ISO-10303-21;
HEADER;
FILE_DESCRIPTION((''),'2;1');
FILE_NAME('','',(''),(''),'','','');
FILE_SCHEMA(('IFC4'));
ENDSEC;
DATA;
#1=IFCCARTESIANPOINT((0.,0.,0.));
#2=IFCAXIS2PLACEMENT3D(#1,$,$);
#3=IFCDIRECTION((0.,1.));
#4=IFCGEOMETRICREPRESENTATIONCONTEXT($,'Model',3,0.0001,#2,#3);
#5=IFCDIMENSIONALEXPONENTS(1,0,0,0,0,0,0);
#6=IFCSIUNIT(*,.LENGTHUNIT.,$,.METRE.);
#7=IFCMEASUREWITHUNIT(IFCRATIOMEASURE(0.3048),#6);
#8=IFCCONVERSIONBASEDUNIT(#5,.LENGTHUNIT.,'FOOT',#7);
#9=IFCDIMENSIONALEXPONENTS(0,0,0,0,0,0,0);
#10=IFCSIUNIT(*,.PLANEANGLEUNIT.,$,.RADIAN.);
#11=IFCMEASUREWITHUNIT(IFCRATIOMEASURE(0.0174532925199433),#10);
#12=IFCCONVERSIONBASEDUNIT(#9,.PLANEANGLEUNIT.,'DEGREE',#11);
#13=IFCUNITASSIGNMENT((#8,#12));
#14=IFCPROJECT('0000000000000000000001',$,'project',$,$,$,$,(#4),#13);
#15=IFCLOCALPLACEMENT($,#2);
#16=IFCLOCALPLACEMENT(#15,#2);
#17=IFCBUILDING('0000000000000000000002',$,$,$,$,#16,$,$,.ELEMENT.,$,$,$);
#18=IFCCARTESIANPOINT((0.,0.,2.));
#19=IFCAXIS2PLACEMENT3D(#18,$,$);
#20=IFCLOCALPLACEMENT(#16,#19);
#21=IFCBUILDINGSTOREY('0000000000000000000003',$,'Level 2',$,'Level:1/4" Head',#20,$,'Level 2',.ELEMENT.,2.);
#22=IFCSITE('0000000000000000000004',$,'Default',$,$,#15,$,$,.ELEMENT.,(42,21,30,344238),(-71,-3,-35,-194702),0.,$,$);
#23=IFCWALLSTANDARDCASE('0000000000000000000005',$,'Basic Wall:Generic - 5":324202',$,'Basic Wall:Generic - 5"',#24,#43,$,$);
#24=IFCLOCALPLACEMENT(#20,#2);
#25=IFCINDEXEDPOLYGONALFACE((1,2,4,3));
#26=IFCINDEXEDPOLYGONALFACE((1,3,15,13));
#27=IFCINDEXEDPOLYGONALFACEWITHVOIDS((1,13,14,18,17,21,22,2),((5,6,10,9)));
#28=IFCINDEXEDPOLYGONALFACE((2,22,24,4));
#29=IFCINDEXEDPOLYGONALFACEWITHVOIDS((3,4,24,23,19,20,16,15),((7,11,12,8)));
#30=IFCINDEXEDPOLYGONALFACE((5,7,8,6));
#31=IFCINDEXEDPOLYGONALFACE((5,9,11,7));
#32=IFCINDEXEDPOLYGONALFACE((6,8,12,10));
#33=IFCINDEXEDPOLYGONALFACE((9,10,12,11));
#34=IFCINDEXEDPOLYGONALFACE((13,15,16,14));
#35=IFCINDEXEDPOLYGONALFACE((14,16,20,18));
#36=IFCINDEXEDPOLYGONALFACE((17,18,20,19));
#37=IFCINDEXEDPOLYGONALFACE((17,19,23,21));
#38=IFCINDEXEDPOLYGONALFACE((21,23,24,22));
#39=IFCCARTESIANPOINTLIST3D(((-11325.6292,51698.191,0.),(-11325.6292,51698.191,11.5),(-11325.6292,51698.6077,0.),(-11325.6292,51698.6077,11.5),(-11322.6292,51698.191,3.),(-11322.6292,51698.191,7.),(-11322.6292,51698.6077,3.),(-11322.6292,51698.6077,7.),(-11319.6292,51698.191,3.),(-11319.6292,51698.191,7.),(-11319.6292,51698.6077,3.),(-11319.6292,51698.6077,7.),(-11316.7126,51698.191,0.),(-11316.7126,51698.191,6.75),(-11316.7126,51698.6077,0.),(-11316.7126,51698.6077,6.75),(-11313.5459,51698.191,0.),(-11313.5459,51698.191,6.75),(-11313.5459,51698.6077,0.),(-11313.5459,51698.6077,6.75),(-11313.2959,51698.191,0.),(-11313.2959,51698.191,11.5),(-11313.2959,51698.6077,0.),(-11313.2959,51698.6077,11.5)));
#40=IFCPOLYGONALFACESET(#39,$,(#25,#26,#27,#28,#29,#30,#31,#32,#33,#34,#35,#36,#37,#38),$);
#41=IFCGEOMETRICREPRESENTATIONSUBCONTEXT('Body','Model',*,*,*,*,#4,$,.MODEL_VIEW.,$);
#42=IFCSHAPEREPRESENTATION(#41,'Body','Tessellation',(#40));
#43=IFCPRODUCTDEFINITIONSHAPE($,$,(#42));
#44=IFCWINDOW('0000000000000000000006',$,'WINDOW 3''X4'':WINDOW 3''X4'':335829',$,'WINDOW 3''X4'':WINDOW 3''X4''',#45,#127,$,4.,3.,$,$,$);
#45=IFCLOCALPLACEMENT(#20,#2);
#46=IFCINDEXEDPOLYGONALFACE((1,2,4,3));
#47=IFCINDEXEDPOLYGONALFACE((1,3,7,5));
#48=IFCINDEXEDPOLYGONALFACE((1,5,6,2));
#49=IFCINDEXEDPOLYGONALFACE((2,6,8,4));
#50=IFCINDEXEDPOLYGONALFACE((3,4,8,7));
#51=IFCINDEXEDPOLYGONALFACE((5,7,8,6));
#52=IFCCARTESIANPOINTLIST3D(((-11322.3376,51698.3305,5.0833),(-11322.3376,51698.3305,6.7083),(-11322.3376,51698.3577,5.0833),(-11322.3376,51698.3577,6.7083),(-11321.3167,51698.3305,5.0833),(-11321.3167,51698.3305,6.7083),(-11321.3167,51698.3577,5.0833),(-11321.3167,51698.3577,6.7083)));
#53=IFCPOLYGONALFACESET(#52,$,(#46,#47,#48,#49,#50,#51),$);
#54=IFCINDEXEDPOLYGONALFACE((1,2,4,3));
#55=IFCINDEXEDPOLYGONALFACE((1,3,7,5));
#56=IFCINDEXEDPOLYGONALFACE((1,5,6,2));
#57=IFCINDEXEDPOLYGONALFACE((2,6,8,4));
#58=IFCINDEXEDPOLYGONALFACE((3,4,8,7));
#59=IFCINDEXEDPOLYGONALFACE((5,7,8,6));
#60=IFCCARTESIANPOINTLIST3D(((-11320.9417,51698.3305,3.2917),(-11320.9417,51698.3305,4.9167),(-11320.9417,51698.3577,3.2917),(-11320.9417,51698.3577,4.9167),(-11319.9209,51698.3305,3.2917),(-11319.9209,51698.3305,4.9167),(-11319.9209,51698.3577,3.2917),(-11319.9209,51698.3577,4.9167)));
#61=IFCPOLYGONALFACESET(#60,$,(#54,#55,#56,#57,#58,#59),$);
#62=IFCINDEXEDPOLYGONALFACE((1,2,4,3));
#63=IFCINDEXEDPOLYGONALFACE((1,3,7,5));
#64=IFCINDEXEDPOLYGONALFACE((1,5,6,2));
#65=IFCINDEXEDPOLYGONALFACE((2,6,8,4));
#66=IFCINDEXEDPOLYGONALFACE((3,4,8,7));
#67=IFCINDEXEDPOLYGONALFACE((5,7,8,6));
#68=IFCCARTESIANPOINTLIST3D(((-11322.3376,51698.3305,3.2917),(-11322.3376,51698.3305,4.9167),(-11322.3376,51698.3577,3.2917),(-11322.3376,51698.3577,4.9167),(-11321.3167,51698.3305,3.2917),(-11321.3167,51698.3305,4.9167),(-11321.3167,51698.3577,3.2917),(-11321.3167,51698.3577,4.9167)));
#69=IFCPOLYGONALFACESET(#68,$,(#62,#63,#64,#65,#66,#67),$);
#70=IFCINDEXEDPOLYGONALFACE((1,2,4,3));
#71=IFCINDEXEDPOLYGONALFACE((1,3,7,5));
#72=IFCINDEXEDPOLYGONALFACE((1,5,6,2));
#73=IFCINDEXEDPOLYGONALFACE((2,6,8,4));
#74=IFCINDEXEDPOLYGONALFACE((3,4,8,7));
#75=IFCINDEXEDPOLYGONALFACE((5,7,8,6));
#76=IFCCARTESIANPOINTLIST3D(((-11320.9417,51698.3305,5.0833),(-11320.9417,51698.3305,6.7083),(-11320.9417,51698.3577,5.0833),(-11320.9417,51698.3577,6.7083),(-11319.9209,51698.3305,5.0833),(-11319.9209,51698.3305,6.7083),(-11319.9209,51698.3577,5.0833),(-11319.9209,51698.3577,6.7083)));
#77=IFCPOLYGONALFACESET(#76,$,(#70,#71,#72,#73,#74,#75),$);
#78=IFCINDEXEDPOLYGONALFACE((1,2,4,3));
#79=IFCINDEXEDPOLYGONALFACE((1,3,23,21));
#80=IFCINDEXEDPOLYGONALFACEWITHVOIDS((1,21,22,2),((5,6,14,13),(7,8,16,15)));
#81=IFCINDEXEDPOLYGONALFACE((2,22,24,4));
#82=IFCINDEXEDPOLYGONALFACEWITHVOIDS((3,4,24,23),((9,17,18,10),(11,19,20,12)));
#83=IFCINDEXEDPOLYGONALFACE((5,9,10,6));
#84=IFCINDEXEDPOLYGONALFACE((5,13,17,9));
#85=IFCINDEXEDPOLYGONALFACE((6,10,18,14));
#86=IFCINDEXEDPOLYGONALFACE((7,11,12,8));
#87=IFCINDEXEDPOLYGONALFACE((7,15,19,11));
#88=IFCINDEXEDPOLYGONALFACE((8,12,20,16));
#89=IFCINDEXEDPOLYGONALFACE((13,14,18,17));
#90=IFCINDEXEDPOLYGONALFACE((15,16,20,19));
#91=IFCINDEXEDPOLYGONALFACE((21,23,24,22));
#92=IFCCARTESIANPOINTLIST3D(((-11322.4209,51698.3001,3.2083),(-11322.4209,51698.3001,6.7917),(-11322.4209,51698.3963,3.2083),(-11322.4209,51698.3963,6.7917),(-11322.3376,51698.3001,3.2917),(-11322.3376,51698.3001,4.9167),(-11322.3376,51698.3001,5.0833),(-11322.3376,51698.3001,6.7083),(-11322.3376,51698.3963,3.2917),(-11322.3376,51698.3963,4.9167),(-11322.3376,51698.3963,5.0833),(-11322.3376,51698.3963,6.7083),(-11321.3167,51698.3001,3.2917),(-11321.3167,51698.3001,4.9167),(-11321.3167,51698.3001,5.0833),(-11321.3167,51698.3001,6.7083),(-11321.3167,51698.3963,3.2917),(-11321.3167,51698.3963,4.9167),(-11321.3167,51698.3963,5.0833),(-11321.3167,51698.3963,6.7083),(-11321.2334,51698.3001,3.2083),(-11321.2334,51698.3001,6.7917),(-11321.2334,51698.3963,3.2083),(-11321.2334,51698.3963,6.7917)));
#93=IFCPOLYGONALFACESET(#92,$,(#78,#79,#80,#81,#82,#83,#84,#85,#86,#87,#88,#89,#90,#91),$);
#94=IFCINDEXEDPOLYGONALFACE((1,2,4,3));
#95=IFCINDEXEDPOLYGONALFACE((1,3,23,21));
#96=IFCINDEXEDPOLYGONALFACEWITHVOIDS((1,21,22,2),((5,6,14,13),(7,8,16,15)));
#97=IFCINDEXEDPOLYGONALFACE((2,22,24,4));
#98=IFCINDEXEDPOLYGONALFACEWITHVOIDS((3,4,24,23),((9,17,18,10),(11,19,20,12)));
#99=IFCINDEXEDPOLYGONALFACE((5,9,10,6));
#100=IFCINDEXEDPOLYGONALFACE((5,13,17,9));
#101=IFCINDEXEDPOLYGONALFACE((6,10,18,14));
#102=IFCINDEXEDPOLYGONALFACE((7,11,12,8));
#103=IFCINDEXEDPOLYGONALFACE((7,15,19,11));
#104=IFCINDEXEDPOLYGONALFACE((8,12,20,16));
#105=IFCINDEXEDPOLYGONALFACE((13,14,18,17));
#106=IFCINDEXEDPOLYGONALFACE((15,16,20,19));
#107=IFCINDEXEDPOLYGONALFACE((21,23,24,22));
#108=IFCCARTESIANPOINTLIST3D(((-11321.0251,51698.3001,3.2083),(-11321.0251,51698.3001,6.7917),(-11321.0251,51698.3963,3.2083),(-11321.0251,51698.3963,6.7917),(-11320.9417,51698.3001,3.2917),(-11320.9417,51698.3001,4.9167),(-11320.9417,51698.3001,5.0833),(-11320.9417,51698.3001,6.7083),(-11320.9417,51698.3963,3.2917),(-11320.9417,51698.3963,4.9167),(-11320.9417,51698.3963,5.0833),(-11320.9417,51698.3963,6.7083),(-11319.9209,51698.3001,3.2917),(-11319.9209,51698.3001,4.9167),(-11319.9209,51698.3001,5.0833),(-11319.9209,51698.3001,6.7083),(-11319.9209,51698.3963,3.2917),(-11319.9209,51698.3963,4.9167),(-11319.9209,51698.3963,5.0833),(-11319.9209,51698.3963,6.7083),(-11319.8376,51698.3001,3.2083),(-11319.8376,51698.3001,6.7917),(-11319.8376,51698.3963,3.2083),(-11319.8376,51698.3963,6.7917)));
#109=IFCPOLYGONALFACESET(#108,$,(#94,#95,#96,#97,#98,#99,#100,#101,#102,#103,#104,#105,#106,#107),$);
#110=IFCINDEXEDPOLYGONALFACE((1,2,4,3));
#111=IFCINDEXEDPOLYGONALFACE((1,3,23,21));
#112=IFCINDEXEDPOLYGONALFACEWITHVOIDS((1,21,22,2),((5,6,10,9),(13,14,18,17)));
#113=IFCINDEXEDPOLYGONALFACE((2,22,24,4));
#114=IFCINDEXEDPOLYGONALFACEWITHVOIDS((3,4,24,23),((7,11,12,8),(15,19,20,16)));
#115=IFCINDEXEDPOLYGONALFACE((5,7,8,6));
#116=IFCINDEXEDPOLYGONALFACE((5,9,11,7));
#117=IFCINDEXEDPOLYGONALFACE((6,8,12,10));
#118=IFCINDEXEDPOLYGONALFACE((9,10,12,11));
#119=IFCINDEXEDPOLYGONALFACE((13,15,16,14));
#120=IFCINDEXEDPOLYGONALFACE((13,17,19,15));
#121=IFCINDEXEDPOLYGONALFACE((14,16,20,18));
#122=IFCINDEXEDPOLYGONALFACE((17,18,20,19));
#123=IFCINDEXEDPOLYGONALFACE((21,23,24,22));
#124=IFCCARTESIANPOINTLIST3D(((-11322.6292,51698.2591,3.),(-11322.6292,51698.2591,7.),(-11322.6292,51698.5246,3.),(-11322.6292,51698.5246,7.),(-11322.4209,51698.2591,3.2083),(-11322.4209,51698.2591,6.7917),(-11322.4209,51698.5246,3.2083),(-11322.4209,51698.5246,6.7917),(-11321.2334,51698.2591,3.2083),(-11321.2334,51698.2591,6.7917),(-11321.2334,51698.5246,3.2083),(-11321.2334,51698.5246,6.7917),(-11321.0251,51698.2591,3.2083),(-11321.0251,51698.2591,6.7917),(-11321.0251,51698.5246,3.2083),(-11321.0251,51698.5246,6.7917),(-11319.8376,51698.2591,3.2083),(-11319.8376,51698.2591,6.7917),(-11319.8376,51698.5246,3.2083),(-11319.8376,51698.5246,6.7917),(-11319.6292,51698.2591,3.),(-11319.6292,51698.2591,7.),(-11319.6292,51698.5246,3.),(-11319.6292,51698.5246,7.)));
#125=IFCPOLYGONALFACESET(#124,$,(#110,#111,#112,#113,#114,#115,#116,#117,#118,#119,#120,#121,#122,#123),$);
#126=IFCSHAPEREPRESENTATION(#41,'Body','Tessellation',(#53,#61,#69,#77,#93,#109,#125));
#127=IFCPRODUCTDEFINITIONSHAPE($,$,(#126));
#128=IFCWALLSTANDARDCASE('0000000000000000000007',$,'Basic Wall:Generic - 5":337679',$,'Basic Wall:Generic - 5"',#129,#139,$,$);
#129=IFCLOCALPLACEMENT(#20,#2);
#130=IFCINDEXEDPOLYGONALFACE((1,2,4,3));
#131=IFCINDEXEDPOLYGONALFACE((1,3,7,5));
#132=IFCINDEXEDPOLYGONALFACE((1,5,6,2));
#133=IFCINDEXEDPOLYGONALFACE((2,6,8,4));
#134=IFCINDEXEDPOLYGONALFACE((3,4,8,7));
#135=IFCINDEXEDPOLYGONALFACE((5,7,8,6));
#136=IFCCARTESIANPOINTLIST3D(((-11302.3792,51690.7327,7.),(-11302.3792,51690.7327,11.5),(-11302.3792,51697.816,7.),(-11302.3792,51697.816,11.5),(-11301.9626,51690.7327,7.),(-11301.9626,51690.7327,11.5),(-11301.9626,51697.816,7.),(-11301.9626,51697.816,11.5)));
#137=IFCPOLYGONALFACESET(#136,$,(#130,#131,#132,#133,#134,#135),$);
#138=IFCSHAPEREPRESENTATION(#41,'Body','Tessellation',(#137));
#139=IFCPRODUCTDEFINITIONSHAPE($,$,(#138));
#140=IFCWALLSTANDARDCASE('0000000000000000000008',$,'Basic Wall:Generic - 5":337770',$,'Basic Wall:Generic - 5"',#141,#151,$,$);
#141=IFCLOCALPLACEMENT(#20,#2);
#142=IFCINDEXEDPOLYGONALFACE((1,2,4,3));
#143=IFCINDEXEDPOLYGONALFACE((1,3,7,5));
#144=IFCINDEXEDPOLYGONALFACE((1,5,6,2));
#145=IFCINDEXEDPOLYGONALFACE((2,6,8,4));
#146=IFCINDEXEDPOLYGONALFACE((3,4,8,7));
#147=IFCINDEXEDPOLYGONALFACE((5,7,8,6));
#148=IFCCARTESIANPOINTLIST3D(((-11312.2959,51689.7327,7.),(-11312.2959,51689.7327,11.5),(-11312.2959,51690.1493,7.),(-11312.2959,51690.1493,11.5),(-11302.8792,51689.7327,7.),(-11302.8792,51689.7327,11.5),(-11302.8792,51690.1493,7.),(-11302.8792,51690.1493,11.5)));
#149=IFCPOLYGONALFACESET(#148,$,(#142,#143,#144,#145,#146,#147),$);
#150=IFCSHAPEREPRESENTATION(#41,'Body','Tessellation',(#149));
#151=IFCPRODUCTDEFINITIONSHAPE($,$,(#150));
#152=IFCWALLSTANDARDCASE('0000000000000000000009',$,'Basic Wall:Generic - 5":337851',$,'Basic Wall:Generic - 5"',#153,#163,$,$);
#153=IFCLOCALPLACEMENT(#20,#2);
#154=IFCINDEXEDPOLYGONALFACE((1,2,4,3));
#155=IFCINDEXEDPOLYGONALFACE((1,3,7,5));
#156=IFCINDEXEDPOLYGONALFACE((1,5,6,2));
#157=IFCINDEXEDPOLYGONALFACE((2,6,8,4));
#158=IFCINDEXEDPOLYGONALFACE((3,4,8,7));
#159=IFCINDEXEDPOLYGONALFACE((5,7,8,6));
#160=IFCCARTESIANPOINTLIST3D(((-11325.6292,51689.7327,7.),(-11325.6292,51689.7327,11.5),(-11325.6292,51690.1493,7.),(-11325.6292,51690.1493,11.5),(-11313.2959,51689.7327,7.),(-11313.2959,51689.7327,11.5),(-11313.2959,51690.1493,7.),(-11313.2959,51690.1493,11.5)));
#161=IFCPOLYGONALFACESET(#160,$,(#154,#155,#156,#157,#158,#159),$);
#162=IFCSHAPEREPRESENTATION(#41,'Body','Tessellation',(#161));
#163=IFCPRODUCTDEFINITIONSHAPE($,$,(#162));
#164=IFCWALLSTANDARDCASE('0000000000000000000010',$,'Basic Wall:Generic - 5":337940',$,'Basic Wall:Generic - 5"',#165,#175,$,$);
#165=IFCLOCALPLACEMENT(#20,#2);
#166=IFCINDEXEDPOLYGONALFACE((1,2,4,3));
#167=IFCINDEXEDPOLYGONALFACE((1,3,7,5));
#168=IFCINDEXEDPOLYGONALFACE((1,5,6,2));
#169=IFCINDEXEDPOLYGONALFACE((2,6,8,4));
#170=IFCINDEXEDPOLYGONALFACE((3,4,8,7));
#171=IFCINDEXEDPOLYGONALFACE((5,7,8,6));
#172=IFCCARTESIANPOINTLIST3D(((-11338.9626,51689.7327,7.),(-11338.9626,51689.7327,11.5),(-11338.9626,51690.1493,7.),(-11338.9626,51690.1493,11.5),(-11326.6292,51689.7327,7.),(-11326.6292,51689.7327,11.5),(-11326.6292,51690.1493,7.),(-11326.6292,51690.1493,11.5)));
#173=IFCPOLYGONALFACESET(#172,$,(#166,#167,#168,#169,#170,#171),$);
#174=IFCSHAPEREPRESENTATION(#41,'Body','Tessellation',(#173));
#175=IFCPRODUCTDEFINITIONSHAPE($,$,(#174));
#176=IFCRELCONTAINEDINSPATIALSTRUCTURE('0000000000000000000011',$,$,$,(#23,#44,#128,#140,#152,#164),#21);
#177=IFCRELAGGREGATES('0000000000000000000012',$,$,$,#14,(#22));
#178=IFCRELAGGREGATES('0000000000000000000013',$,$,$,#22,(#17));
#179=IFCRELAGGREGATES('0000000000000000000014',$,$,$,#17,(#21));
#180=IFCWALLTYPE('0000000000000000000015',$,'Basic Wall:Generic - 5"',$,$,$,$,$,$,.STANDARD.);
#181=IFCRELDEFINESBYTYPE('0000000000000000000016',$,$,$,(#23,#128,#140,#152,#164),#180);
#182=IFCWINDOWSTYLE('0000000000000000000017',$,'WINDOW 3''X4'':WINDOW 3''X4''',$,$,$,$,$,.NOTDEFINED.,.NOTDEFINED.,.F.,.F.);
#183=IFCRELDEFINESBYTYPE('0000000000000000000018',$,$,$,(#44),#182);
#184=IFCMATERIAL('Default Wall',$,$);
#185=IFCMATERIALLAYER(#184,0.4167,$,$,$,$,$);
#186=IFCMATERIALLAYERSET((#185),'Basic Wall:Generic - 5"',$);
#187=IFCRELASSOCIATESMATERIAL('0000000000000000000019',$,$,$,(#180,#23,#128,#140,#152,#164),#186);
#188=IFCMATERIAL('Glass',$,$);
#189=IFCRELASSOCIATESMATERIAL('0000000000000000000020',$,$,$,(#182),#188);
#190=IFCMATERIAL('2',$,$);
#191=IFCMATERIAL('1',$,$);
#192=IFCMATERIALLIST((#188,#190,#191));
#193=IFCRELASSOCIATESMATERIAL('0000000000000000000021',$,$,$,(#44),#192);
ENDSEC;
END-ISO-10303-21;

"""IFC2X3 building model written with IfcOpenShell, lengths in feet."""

from ifc_helpers import new_model, entity, si_unit, converted_unit, direction, frame, frame_2d, origin, origin_2d_with_axis, place, context, subcontext, project, spatial, polyline, rectangle, outline, extrude, source, transform, mapped, material, material_list, layer, layer_set, layer_usage, type_object, type_shapes, element, fill, save


model = new_model("IFC2X3")

# Units and contexts
model_context = context("Model", 3, precision=0.0001, world=origin(), true_north=direction((0.0, 1.0)))
body_context = subcontext(model_context, "Body", "Model", "MODEL_VIEW")
ifc_project = project(units=[converted_unit("LENGTHUNIT", "FOOT", entity("IfcRatioMeasure", 0.3048), si_unit("LENGTHUNIT", "METRE"), dimensions=[1, 0, 0, 0, 0, 0, 0]), converted_unit("PLANEANGLEUNIT", "DEGREE", entity("IfcRatioMeasure", 0.0174532925199433), si_unit("PLANEANGLEUNIT", "RADIAN"), dimensions=[0, 0, 0, 0, 0, 0, 0])], contexts=[model_context])

# Site, building, storey
site_placement = place(None, origin())
site = spatial("IfcSite", under=ifc_project, at=site_placement, Name="Default", CompositionType="ELEMENT", RefLatitude=(42, 21, 30, 344238), RefLongitude=(-71, -3, -35, -194702), RefElevation=0.0)
building_placement = place(site_placement, origin())
building = spatial("IfcBuilding", under=site, at=building_placement, CompositionType="ELEMENT")
storey_placement = place(building_placement, frame((0.0, 0.0, 2.0)))
storey = spatial("IfcBuildingStorey", under=building, at=storey_placement, Name="Level 2", ObjectType="Level:1/4\" Head", LongName="Level 2", CompositionType="ELEMENT", Elevation=2.0)

# Wall, openings, window
ifc_material_1 = material(Name="Default Wall")
ifc_layer_1 = layer(ifc_material_1, 0.4167)
ifc_layer_set_1 = layer_set([ifc_layer_1], Name="Basic Wall:Generic - 5\"")
wall_type = type_object("IfcWallType", Name="Basic Wall:Generic - 5\"", PredefinedType="STANDARD", material=ifc_layer_set_1)
ifc_material_2 = material(Name="Glass")
ifc_material_3 = material(Name="2")
ifc_material_4 = material(Name="1")
window_style = type_object("IfcWindowStyle", Name="WINDOW 3'X4':WINDOW 3'X4'", ConstructionType="NOTDEFINED", OperationType="NOTDEFINED", ParameterTakesPrecedence=False, Sizeable=False, material=ifc_material_2)
shared_shape = source(origin(), body_context, "Body", "SweptSolid", [
    extrude(rectangle(XDim=0.0272, YDim=1.0208, at=origin_2d_with_axis()), frame((2.1979, 0.2636, 2.0833), z_axis=(0.0, 0.0, 1.0), x_axis=(0.0, 1.0, 0.0)), (0.0, 0.0, 1.0), 1.625),
    extrude(rectangle(XDim=0.0272, YDim=1.0208, at=origin_2d_with_axis()), frame((0.8021, 0.2636, 0.2917), z_axis=(0.0, 0.0, 1.0), x_axis=(0.0, 1.0, 0.0)), (0.0, 0.0, 1.0), 1.625),
    extrude(rectangle(XDim=0.0272, YDim=1.0208, at=origin_2d_with_axis()), frame((2.1979, 0.2636, 0.2917), z_axis=(0.0, 0.0, 1.0), x_axis=(0.0, 1.0, 0.0)), (0.0, 0.0, 1.0), 1.625),
    extrude(rectangle(XDim=0.0272, YDim=1.0208, at=origin_2d_with_axis()), frame((0.8021, 0.2636, 2.0833), z_axis=(0.0, 0.0, 1.0), x_axis=(0.0, 1.0, 0.0)), (0.0, 0.0, 1.0), 1.625),
    extrude(outline(polyline([(-0.5938, -1.7917), (0.5938, -1.7917), (0.5938, 1.7917), (-0.5938, 1.7917), (-0.5938, -1.7917)]), holes=[polyline([(-0.5104, -0.0833), (0.5104, -0.0833), (0.5104, -1.7083), (-0.5104, -1.7083), (-0.5104, -0.0833)]), polyline([(-0.5104, 1.7083), (0.5104, 1.7083), (0.5104, 0.0833), (-0.5104, 0.0833), (-0.5104, 1.7083)])]), frame((2.1979, 0.2114, 2.0), z_axis=(0.0, 1.0, 0.0), x_axis=(-1.0, 0.0, 0.0)), (0.0, 0.0, 1.0), 0.0962),
    extrude(outline(polyline([(-1.7917, -0.5937), (1.7917, -0.5937), (1.7917, 0.5937), (-1.7917, 0.5937), (-1.7917, -0.5937)]), holes=[polyline([(0.0833, -0.5104), (0.0833, 0.5104), (1.7083, 0.5104), (1.7083, -0.5104), (0.0833, -0.5104)]), polyline([(-1.7083, -0.5104), (-1.7083, 0.5104), (-0.0833, 0.5104), (-0.0833, -0.5104), (-1.7083, -0.5104)])]), frame((0.8021, 0.2114, 2.0), z_axis=(0.0, 1.0, 0.0), x_axis=(0.0, 0.0, -1.0)), (0.0, 0.0, 1.0), 0.0962),
    extrude(outline(polyline([(-1.5, -2.0), (1.5, -2.0), (1.5, 2.0), (-1.5, 2.0), (-1.5, -2.0)]), holes=[polyline([(-0.1042, 1.7917), (-0.1042, -1.7917), (-1.2917, -1.7917), (-1.2917, 1.7917), (-0.1042, 1.7917)]), polyline([(0.1042, -1.7917), (0.1042, 1.7917), (1.2917, 1.7917), (1.2917, -1.7917), (0.1042, -1.7917)])]), frame((1.5, 0.0831, 2.0), z_axis=(0.0, 1.0, 0.0), x_axis=(1.0, 0.0, 0.0)), (0.0, 0.0, 1.0), 0.2655),
])
type_shapes(window_style, [shared_shape])
ifc_layer_usage_1 = layer_usage(ifc_layer_set_1, "AXIS2", "NEGATIVE", 0.2083)
wall_1_placement = place(storey_placement, frame((-11325.6292, 51698.3993, 0.0)))
wall_1 = element("IfcWallStandardCase", 1, at=wall_1_placement, inside=storey, type_object=wall_type, material=ifc_layer_usage_1, Name="Basic Wall:Generic - 5\":324202", ObjectType="Basic Wall:Generic - 5\"", context=body_context, shape_type="SweptSolid", body=[
    extrude(rectangle(XDim=12.3333, YDim=0.4167, at=frame_2d((6.1667, 0.0), x_axis=(-1.0, 0.0))), origin(), (0.0, 0.0, 1.0), 11.5),
])
opening_1_placement = place(wall_1_placement, frame((8.9167, -0.2083, 0.0)))
element("IfcOpeningElement", 2, at=opening_1_placement, cuts=wall_1, ObjectType="Opening", context=body_context, shape_type="SweptSolid", body=[
    extrude(rectangle(XDim=6.75, YDim=3.1667, at=frame_2d((3.375, 1.5833), x_axis=(1.0, 0.0))), frame((0.0, 0.0, 0.0), z_axis=(0.0, 1.0, 0.0), x_axis=(0.0, 0.0, 1.0)), (0.0, 0.0, 1.0), 0.4167),
])
opening_2_placement = place(wall_1_placement, frame((6.0, 0.2083, 3.0)))
opening_2 = element("IfcOpeningElement", 3, at=opening_2_placement, cuts=wall_1, ObjectType="Opening", context=body_context, shape_type="SweptSolid", body=[
    extrude(rectangle(XDim=4.0, YDim=3.0, at=frame_2d((2.0, 1.5), x_axis=(-1.0, 0.0))), frame((0.0, 0.0, 0.0), z_axis=(0.0, -1.0, 0.0), x_axis=(0.0, 0.0, 1.0)), (0.0, 0.0, 1.0), 0.4167),
])
ifc_material_list_1 = material_list([ifc_material_2, ifc_material_3, ifc_material_4])
window_1_placement = place(opening_2_placement, frame((0.0, 0.0, 0.0), z_axis=(0.0, 0.0, 1.0), x_axis=(-1.0, 0.0, 0.0)))
window_1 = element("IfcWindow", 4, at=window_1_placement, inside=storey, type_object=window_style, material=ifc_material_list_1, Name="WINDOW 3'X4':WINDOW 3'X4':335829", ObjectType="WINDOW 3'X4':WINDOW 3'X4'", OverallHeight=4.0, OverallWidth=3.0, context=body_context, shape_type="MappedRepresentation", body=[
    mapped(shared_shape, transform((0.0, 0.0, 0.0), scale=1.0)),
])
fill(opening_2, window_1)

# Walls
ifc_layer_usage_2 = layer_usage(ifc_layer_set_1, "AXIS2", "NEGATIVE", 0.2083)
wall_2_placement = place(storey_placement, frame((-11302.1709, 51697.816, 7.0), z_axis=(0.0, 0.0, 1.0), x_axis=(0.0, -1.0, 0.0)))
element("IfcWallStandardCase", 5, at=wall_2_placement, inside=storey, type_object=wall_type, material=ifc_layer_usage_2, Name="Basic Wall:Generic - 5\":337679", ObjectType="Basic Wall:Generic - 5\"", context=body_context, shape_type="SweptSolid", body=[
    extrude(rectangle(XDim=7.0833, YDim=0.4167, at=frame_2d((3.5417, 0.0), x_axis=(-1.0, 0.0))), origin(), (0.0, 0.0, 1.0), 4.5),
])
ifc_layer_usage_3 = layer_usage(ifc_layer_set_1, "AXIS2", "NEGATIVE", 0.2083)
wall_3_placement = place(storey_placement, frame((-11302.8792, 51689.941, 7.0), z_axis=(0.0, 0.0, 1.0), x_axis=(-1.0, 0.0, 0.0)))
element("IfcWallStandardCase", 6, at=wall_3_placement, inside=storey, type_object=wall_type, material=ifc_layer_usage_3, Name="Basic Wall:Generic - 5\":337770", ObjectType="Basic Wall:Generic - 5\"", context=body_context, shape_type="SweptSolid", body=[
    extrude(rectangle(XDim=9.4167, YDim=0.4167, at=frame_2d((4.7083, 0.0), x_axis=(-1.0, 0.0))), origin(), (0.0, 0.0, 1.0), 4.5),
])
ifc_layer_usage_4 = layer_usage(ifc_layer_set_1, "AXIS2", "NEGATIVE", 0.2083)
wall_4_placement = place(storey_placement, frame((-11313.2959, 51689.941, 7.0), z_axis=(0.0, 0.0, 1.0), x_axis=(-1.0, 0.0, 0.0)))
element("IfcWallStandardCase", 7, at=wall_4_placement, inside=storey, type_object=wall_type, material=ifc_layer_usage_4, Name="Basic Wall:Generic - 5\":337851", ObjectType="Basic Wall:Generic - 5\"", context=body_context, shape_type="SweptSolid", body=[
    extrude(rectangle(XDim=12.3333, YDim=0.4167, at=frame_2d((6.1667, 0.0), x_axis=(-1.0, 0.0))), origin(), (0.0, 0.0, 1.0), 4.5),
])
ifc_layer_usage_5 = layer_usage(ifc_layer_set_1, "AXIS2", "NEGATIVE", 0.2083)
wall_5_placement = place(storey_placement, frame((-11326.6292, 51689.941, 7.0), z_axis=(0.0, 0.0, 1.0), x_axis=(-1.0, 0.0, 0.0)))
element("IfcWallStandardCase", 8, at=wall_5_placement, inside=storey, type_object=wall_type, material=ifc_layer_usage_5, Name="Basic Wall:Generic - 5\":337940", ObjectType="Basic Wall:Generic - 5\"", context=body_context, shape_type="SweptSolid", body=[
    extrude(rectangle(XDim=12.3333, YDim=0.4167, at=frame_2d((6.1667, 0.0), x_axis=(-1.0, 0.0))), origin(), (0.0, 0.0, 1.0), 4.5),
])

save(model, "model.ifc")
